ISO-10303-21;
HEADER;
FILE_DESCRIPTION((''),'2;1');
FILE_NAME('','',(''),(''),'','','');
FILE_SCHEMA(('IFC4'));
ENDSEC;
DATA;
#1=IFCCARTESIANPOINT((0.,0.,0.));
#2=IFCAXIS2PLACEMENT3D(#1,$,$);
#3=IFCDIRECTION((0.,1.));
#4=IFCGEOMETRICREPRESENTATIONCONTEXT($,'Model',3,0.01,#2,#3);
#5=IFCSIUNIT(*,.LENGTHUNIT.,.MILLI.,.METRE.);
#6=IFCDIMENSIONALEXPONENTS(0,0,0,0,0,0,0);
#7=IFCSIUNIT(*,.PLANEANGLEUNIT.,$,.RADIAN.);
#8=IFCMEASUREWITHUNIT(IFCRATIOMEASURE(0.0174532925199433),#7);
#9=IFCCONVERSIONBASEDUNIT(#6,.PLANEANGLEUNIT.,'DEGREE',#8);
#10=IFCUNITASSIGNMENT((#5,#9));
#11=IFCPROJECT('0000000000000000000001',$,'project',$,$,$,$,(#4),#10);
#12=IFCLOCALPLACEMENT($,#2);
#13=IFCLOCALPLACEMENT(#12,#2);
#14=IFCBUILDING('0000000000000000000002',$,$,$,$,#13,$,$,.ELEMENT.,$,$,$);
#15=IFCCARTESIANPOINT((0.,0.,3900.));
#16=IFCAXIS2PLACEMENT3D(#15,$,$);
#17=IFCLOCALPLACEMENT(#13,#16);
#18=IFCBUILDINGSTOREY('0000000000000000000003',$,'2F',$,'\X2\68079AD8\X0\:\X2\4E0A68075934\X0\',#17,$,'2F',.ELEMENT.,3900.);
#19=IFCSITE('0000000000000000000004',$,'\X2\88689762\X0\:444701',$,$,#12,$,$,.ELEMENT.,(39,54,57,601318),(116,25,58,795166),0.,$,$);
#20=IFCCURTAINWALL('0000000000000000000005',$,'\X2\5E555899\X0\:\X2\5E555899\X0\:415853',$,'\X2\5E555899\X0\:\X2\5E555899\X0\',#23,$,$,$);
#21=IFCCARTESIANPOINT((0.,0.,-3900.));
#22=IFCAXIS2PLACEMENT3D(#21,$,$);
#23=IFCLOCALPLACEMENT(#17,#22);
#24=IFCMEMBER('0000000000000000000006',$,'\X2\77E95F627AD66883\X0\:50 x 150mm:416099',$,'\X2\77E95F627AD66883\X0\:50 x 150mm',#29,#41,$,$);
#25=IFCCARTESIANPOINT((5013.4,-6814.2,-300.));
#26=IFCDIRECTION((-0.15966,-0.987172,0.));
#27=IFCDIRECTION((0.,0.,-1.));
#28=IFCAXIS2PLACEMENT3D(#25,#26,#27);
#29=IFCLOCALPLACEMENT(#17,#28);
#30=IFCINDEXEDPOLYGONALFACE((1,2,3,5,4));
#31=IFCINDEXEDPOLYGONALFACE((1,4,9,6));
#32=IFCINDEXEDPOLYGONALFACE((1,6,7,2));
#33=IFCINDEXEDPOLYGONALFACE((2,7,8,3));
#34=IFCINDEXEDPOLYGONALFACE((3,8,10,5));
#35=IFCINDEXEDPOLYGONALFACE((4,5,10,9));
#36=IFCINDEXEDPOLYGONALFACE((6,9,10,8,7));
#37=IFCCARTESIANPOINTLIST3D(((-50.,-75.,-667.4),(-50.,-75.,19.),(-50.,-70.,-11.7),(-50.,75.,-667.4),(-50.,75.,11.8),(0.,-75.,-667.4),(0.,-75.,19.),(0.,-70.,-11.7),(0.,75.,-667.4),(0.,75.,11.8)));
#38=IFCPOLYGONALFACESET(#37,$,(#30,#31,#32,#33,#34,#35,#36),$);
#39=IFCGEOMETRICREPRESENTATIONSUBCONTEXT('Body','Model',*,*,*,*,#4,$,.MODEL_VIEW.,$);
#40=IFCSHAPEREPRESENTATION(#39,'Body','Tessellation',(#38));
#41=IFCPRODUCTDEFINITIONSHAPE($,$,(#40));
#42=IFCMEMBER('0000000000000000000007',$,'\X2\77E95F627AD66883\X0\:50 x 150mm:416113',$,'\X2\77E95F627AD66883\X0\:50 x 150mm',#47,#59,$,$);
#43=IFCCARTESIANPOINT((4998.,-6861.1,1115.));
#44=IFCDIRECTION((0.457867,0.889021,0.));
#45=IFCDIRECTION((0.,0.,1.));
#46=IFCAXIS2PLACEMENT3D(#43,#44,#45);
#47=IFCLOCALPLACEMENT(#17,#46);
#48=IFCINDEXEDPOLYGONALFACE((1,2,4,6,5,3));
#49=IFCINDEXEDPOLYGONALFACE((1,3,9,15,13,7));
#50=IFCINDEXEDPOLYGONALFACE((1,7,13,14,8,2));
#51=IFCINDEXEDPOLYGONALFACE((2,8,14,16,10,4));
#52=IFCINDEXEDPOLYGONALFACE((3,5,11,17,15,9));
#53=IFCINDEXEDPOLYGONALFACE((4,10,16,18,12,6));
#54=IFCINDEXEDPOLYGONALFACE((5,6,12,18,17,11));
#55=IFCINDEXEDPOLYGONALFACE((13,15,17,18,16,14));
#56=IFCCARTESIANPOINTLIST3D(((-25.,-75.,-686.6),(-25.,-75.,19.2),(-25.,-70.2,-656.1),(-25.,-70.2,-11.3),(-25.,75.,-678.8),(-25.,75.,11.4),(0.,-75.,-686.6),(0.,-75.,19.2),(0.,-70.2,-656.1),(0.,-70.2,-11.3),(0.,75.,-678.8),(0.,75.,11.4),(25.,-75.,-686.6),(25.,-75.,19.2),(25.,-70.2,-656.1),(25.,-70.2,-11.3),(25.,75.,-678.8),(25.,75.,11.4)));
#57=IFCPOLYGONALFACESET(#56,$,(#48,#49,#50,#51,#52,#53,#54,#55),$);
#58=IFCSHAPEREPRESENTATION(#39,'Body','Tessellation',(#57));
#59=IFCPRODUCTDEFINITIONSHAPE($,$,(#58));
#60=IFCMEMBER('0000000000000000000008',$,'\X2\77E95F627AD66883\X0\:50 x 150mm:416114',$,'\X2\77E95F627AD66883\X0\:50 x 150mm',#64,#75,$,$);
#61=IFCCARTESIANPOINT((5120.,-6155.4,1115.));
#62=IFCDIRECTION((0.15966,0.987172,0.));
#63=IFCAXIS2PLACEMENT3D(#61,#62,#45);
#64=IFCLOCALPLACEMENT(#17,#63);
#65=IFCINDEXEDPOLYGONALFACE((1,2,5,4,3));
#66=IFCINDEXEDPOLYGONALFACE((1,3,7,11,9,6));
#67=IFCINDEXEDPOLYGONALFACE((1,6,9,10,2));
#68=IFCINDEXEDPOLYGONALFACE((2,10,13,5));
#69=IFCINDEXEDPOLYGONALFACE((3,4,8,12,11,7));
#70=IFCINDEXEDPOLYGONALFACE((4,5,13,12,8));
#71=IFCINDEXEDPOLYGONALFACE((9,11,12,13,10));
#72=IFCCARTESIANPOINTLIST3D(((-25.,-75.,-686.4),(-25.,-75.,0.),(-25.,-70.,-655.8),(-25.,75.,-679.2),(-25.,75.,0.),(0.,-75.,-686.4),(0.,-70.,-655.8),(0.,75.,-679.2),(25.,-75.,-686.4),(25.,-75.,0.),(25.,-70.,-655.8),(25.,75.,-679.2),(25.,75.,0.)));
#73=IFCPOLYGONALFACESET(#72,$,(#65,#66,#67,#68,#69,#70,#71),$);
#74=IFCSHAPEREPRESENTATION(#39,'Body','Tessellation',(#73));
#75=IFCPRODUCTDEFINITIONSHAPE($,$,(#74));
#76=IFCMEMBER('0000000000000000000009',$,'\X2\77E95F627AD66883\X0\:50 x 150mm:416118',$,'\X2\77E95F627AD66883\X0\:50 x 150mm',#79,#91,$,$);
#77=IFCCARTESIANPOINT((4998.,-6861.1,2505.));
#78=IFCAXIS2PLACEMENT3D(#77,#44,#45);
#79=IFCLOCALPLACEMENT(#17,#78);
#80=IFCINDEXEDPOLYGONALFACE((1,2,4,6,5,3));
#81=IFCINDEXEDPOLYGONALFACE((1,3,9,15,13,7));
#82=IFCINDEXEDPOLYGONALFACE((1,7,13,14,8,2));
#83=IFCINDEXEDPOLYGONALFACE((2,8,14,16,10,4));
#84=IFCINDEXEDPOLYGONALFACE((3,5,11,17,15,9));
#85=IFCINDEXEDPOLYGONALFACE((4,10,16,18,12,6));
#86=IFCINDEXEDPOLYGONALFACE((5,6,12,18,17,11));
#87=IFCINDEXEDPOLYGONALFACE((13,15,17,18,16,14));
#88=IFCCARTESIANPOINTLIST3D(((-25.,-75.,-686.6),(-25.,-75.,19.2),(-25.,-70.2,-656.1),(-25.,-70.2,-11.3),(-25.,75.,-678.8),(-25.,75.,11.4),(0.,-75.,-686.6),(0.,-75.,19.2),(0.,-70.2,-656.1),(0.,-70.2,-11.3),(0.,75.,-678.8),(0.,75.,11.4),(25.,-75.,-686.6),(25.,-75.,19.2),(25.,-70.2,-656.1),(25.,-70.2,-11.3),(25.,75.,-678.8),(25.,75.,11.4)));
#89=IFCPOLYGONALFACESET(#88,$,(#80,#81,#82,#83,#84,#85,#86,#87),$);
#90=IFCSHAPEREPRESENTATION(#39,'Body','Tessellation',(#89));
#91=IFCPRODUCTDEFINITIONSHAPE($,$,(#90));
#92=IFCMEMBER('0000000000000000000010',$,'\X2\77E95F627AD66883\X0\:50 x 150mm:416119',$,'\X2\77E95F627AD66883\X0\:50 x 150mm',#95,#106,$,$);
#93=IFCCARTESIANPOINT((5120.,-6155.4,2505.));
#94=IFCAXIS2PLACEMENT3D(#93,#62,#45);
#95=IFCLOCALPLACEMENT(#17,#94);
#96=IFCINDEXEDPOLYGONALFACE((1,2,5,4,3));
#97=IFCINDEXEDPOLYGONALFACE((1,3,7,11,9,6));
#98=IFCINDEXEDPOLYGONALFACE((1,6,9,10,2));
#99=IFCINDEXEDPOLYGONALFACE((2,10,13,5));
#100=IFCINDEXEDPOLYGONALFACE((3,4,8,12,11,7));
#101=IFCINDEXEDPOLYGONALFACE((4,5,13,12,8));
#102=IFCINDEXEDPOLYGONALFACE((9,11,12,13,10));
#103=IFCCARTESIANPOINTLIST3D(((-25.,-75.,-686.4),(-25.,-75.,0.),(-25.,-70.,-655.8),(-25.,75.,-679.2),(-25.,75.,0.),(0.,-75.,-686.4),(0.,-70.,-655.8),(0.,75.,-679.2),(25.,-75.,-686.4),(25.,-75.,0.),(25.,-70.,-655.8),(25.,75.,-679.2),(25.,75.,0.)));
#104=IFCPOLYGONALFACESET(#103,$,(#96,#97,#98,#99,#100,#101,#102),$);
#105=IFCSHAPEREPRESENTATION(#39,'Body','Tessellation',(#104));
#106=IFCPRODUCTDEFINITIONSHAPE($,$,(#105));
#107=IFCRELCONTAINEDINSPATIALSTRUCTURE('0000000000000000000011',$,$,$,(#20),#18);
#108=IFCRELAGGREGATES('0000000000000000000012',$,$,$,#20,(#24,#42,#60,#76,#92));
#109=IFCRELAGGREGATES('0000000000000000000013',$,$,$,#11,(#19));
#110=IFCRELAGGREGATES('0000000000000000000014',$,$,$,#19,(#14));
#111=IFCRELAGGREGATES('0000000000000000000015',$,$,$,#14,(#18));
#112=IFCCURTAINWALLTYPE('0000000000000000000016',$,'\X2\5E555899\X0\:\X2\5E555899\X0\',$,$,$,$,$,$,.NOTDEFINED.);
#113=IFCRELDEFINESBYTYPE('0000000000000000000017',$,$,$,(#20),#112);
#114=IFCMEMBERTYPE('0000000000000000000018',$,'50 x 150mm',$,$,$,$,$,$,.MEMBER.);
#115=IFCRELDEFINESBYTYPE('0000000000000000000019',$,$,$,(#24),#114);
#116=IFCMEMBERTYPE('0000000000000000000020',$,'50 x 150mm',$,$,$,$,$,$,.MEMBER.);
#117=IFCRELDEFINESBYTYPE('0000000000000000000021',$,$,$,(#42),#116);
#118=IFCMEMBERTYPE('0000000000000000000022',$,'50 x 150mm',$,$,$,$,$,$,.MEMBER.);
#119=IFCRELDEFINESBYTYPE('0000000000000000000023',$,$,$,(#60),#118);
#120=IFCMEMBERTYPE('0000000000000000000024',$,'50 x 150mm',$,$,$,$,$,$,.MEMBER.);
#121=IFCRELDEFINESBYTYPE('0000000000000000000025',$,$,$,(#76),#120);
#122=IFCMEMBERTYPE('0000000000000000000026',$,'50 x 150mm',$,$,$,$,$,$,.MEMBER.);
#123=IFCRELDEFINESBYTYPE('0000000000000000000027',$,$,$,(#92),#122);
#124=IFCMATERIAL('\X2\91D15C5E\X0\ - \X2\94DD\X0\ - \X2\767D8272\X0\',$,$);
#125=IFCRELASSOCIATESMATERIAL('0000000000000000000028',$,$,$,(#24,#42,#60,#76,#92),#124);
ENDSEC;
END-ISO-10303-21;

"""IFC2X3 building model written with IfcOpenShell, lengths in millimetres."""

from ifc_helpers import new_model, entity, si_unit, converted_unit, direction, frame, frame_2d, origin, origin_2d_with_axis, place, context, subcontext, project, spatial, polyline, rectangle, extrude, clip, bounded_halfspace, source, transform, mapped, material, type_object, type_shapes, element, aggregate, save


model = new_model("IFC2X3")

# Units and contexts
model_context = context("Model", 3, precision=0.01, world=origin(), true_north=direction((0.0, 1.0)))
body_context = subcontext(model_context, "Body", "Model", "MODEL_VIEW")
ifc_project = project(units=[si_unit("LENGTHUNIT", "METRE", prefix="MILLI"), converted_unit("PLANEANGLEUNIT", "DEGREE", entity("IfcRatioMeasure", 0.0174532925199433), si_unit("PLANEANGLEUNIT", "RADIAN"), dimensions=[0, 0, 0, 0, 0, 0, 0])], contexts=[model_context])

# Site, building, storey
site_placement = place(None, origin())
site = spatial("IfcSite", under=ifc_project, at=site_placement, Name="表面:444701", CompositionType="ELEMENT", RefLatitude=(39, 54, 57, 601318), RefLongitude=(116, 25, 58, 795166), RefElevation=0.0)
building_placement = place(site_placement, origin())
building = spatial("IfcBuilding", under=site, at=building_placement, CompositionType="ELEMENT")
storey_placement = place(building_placement, frame((0.0, 0.0, 3900.0)))
storey = spatial("IfcBuildingStorey", under=building, at=storey_placement, Name="2F", ObjectType="标高:上标头", LongName="2F", CompositionType="ELEMENT", Elevation=3900.0)

# Curtain wall
curtain_wall_type = type_object("IfcCurtainWallType", Name="幕墙:幕墙", PredefinedType="NOTDEFINED")
curtain_wall_1_placement = place(storey_placement, frame((0.0, 0.0, -3900.0)))
curtain_wall_1 = element("IfcCurtainWall", 1, at=curtain_wall_1_placement, inside=storey, type_object=curtain_wall_type, Name="幕墙:幕墙:415853", ObjectType="幕墙:幕墙")
ifc_material_1 = material(Name="金属 - 铝 - 白色")

# Members
member_type_1 = type_object("IfcMemberType", Name="50 x 150mm", PredefinedType="MEMBER")
shared_shape_1 = source(origin(), body_context, "Body", "Clipping", [
    clip(clip(extrude(rectangle(XDim=50.0, YDim=150.0, at=frame_2d((0.0, 0.0), x_axis=(1.0, 0.0))), frame((-25.0, 0.0, -667.4)), (0.0, 0.0, 1.0), 686.4), bounded_halfspace(frame((0.0, -78.0, 37.7), z_axis=(0.0, 0.987172, 0.15966), x_axis=(-1.0, 0.0, 0.0)), False, frame((-25.0, 0.0, -667.4)), polyline([(-25.0, -70.0), (-25.0, -75.0), (25.0, -75.0), (25.0, -70.0), (-25.0, -70.0)]))), bounded_halfspace(frame((0.0, -70.0, -11.7), z_axis=(0.0, -0.15966, 0.987172), x_axis=(-1.0, 0.0, 0.0)), False, frame((-25.0, 0.0, -667.4)), polyline([(25.0, 75.0), (-25.0, 75.0), (-25.0, -70.0), (25.0, -70.0), (25.0, 75.0)]))),
])
type_shapes(member_type_1, [shared_shape_1])
member_1_placement = place(storey_placement, frame((5013.4, -6814.2, -300.0), z_axis=(-0.15966, -0.987172, 0.0), x_axis=(0.0, 0.0, -1.0)))
member_1 = element("IfcMember", 2, at=member_1_placement, type_object=member_type_1, material=ifc_material_1, Name="矩形竖梃:50 x 150mm:416099", ObjectType="矩形竖梃:50 x 150mm", context=body_context, shape_type="MappedRepresentation", body=[
    mapped(shared_shape_1, transform((0.0, 0.0, 0.0), scale=1.0)),
])
member_type_2 = type_object("IfcMemberType", Name="50 x 150mm", PredefinedType="MEMBER")
shared_shape_2 = source(origin(), body_context, "Body", "Clipping", [
    clip(clip(clip(clip(clip(clip(clip(clip(extrude(rectangle(XDim=150.0, YDim=50.0, at=origin_2d_with_axis()), frame((0.0, 0.0, -686.6), z_axis=(0.0, 0.0, 1.0), x_axis=(0.0, -1.0, 0.0)), (0.0, 0.0, 1.0), 705.8), bounded_halfspace(frame((-1415.0, -70.2, -656.1), z_axis=(0.0, -0.154283, -0.988027), x_axis=(1.0, 0.0, 0.0)), False, frame((0.0, 0.0, -686.6), z_axis=(0.0, 0.0, 1.0), x_axis=(0.0, -1.0, 0.0)), polyline([(70.2, -25.0), (-75.0, -25.0), (-75.0, 0.0), (70.2, 0.0), (70.2, -25.0)]))), bounded_halfspace(frame((0.0, -70.2, -656.1), z_axis=(0.0, -0.154283, -0.988027), x_axis=(1.0, 0.0, 0.0)), False, frame((0.0, 0.0, -686.6), z_axis=(0.0, 0.0, 1.0), x_axis=(0.0, -1.0, 0.0)), polyline([(-75.0, 25.0), (70.2, 25.0), (70.2, 0.0), (-75.0, 0.0), (-75.0, 25.0)]))), bounded_halfspace(frame((-1415.0, -78.0, -705.5), z_axis=(0.0, 0.988027, -0.154283), x_axis=(1.0, 0.0, 0.0)), False, frame((0.0, 0.0, -686.6), z_axis=(0.0, 0.0, 1.0), x_axis=(0.0, -1.0, 0.0)), polyline([(75.0, 0.0), (75.0, -25.0), (70.2, -25.0), (70.2, 0.0), (75.0, 0.0)]))), bounded_halfspace(frame((0.0, -78.0, -705.5), z_axis=(0.0, 0.988027, -0.154283), x_axis=(1.0, 0.0, 0.0)), False, frame((0.0, 0.0, -686.6), z_axis=(0.0, 0.0, 1.0), x_axis=(0.0, -1.0, 0.0)), polyline([(70.2, 25.0), (75.0, 25.0), (75.0, 0.0), (70.2, 0.0), (70.2, 25.0)]))), bounded_halfspace(frame((-1415.0, -70.2, -11.3), z_axis=(0.0, 0.988027, 0.154283), x_axis=(1.0, 0.0, 0.0)), False, frame((0.0, 0.0, -686.6), z_axis=(0.0, 0.0, 1.0), x_axis=(0.0, -1.0, 0.0)), polyline([(70.2, -25.0), (75.0, -25.0), (75.0, 0.0), (70.2, 0.0), (70.2, -25.0)]))), bounded_halfspace(frame((0.0, -70.2, -11.3), z_axis=(0.0, 0.988027, 0.154283), x_axis=(1.0, 0.0, 0.0)), False, frame((0.0, 0.0, -686.6), z_axis=(0.0, 0.0, 1.0), x_axis=(0.0, -1.0, 0.0)), polyline([(75.0, 0.0), (75.0, 25.0), (70.2, 25.0), (70.2, 0.0), (75.0, 0.0)]))), bounded_halfspace(frame((-1415.0, 78.0, 11.9), z_axis=(0.0, -0.154283, 0.988027), x_axis=(1.0, 0.0, 0.0)), False, frame((0.0, 0.0, -686.6), z_axis=(0.0, 0.0, 1.0), x_axis=(0.0, -1.0, 0.0)), polyline([(-75.0, 0.0), (-75.0, -25.0), (70.2, -25.0), (70.2, 0.0), (-75.0, 0.0)]))), bounded_halfspace(frame((0.0, 78.0, 11.9), z_axis=(0.0, -0.154283, 0.988027), x_axis=(1.0, 0.0, 0.0)), False, frame((0.0, 0.0, -686.6), z_axis=(0.0, 0.0, 1.0), x_axis=(0.0, -1.0, 0.0)), polyline([(-75.0, 25.0), (-75.0, 0.0), (70.2, 0.0), (70.2, 25.0), (-75.0, 25.0)]))),
])
type_shapes(member_type_2, [shared_shape_2])
member_2_placement = place(storey_placement, frame((4998.0, -6861.1, 1115.0), z_axis=(0.457867, 0.889021, 0.0), x_axis=(0.0, 0.0, 1.0)))
member_2 = element("IfcMember", 3, at=member_2_placement, type_object=member_type_2, material=ifc_material_1, Name="矩形竖梃:50 x 150mm:416113", ObjectType="矩形竖梃:50 x 150mm", context=body_context, shape_type="MappedRepresentation", body=[
    mapped(shared_shape_2, transform((0.0, 0.0, 0.0), scale=1.0)),
])
member_type_3 = type_object("IfcMemberType", Name="50 x 150mm", PredefinedType="MEMBER")
shared_shape_3 = source(origin(), body_context, "Body", "Clipping", [
    clip(clip(clip(clip(extrude(rectangle(XDim=150.0, YDim=50.0, at=origin_2d_with_axis()), frame((0.0, 0.0, -686.4), z_axis=(0.0, 0.0, 1.0), x_axis=(0.0, -1.0, 0.0)), (0.0, 0.0, 1.0), 686.4), bounded_halfspace(frame((-1415.0, -70.0, -655.8), z_axis=(0.0, -0.15966, -0.987172), x_axis=(1.0, 0.0, 0.0)), False, frame((0.0, 0.0, -686.4), z_axis=(0.0, 0.0, 1.0), x_axis=(0.0, -1.0, 0.0)), polyline([(70.0, -25.0), (-75.0, -25.0), (-75.0, 0.0), (70.0, 0.0), (70.0, -25.0)]))), bounded_halfspace(frame((0.0, -70.0, -655.8), z_axis=(0.0, -0.15966, -0.987172), x_axis=(1.0, 0.0, 0.0)), False, frame((0.0, 0.0, -686.4), z_axis=(0.0, 0.0, 1.0), x_axis=(0.0, -1.0, 0.0)), polyline([(-75.0, 25.0), (70.0, 25.0), (70.0, 0.0), (-75.0, 0.0), (-75.0, 25.0)]))), bounded_halfspace(frame((-1415.0, -78.0, -705.1), z_axis=(0.0, 0.987172, -0.15966), x_axis=(1.0, 0.0, 0.0)), False, frame((0.0, 0.0, -686.4), z_axis=(0.0, 0.0, 1.0), x_axis=(0.0, -1.0, 0.0)), polyline([(75.0, 0.0), (75.0, -25.0), (70.0, -25.0), (70.0, 0.0), (75.0, 0.0)]))), bounded_halfspace(frame((0.0, -78.0, -705.1), z_axis=(0.0, 0.987172, -0.15966), x_axis=(1.0, 0.0, 0.0)), False, frame((0.0, 0.0, -686.4), z_axis=(0.0, 0.0, 1.0), x_axis=(0.0, -1.0, 0.0)), polyline([(70.0, 25.0), (75.0, 25.0), (75.0, 0.0), (70.0, 0.0), (70.0, 25.0)]))),
])
type_shapes(member_type_3, [shared_shape_3])
member_3_placement = place(storey_placement, frame((5120.0, -6155.4, 1115.0), z_axis=(0.15966, 0.987172, 0.0), x_axis=(0.0, 0.0, 1.0)))
member_3 = element("IfcMember", 4, at=member_3_placement, type_object=member_type_3, material=ifc_material_1, Name="矩形竖梃:50 x 150mm:416114", ObjectType="矩形竖梃:50 x 150mm", context=body_context, shape_type="MappedRepresentation", body=[
    mapped(shared_shape_3, transform((0.0, 0.0, 0.0), scale=1.0)),
])
member_type_4 = type_object("IfcMemberType", Name="50 x 150mm", PredefinedType="MEMBER")
shared_shape_4 = source(origin(), body_context, "Body", "Clipping", [
    clip(clip(clip(clip(clip(clip(clip(clip(extrude(rectangle(XDim=150.0, YDim=50.0, at=origin_2d_with_axis()), frame((0.0, 0.0, -686.6), z_axis=(0.0, 0.0, 1.0), x_axis=(0.0, -1.0, 0.0)), (0.0, 0.0, 1.0), 705.8), bounded_halfspace(frame((-1390.0, -70.2, -656.1), z_axis=(0.0, -0.154283, -0.988027), x_axis=(1.0, 0.0, 0.0)), False, frame((0.0, 0.0, -686.6), z_axis=(0.0, 0.0, 1.0), x_axis=(0.0, -1.0, 0.0)), polyline([(70.2, -25.0), (-75.0, -25.0), (-75.0, 0.0), (70.2, 0.0), (70.2, -25.0)]))), bounded_halfspace(frame((0.0, -70.2, -656.1), z_axis=(0.0, -0.154283, -0.988027), x_axis=(1.0, 0.0, 0.0)), False, frame((0.0, 0.0, -686.6), z_axis=(0.0, 0.0, 1.0), x_axis=(0.0, -1.0, 0.0)), polyline([(-75.0, 25.0), (70.2, 25.0), (70.2, 0.0), (-75.0, 0.0), (-75.0, 25.0)]))), bounded_halfspace(frame((-1390.0, -78.0, -705.5), z_axis=(0.0, 0.988027, -0.154283), x_axis=(1.0, 0.0, 0.0)), False, frame((0.0, 0.0, -686.6), z_axis=(0.0, 0.0, 1.0), x_axis=(0.0, -1.0, 0.0)), polyline([(75.0, 0.0), (75.0, -25.0), (70.2, -25.0), (70.2, 0.0), (75.0, 0.0)]))), bounded_halfspace(frame((0.0, -78.0, -705.5), z_axis=(0.0, 0.988027, -0.154283), x_axis=(1.0, 0.0, 0.0)), False, frame((0.0, 0.0, -686.6), z_axis=(0.0, 0.0, 1.0), x_axis=(0.0, -1.0, 0.0)), polyline([(70.2, 25.0), (75.0, 25.0), (75.0, 0.0), (70.2, 0.0), (70.2, 25.0)]))), bounded_halfspace(frame((-1390.0, -70.2, -11.3), z_axis=(0.0, 0.988027, 0.154283), x_axis=(1.0, 0.0, 0.0)), False, frame((0.0, 0.0, -686.6), z_axis=(0.0, 0.0, 1.0), x_axis=(0.0, -1.0, 0.0)), polyline([(70.2, -25.0), (75.0, -25.0), (75.0, 0.0), (70.2, 0.0), (70.2, -25.0)]))), bounded_halfspace(frame((0.0, -70.2, -11.3), z_axis=(0.0, 0.988027, 0.154283), x_axis=(1.0, 0.0, 0.0)), False, frame((0.0, 0.0, -686.6), z_axis=(0.0, 0.0, 1.0), x_axis=(0.0, -1.0, 0.0)), polyline([(75.0, 0.0), (75.0, 25.0), (70.2, 25.0), (70.2, 0.0), (75.0, 0.0)]))), bounded_halfspace(frame((-1390.0, 78.0, 11.9), z_axis=(0.0, -0.154283, 0.988027), x_axis=(1.0, 0.0, 0.0)), False, frame((0.0, 0.0, -686.6), z_axis=(0.0, 0.0, 1.0), x_axis=(0.0, -1.0, 0.0)), polyline([(-75.0, 0.0), (-75.0, -25.0), (70.2, -25.0), (70.2, 0.0), (-75.0, 0.0)]))), bounded_halfspace(frame((0.0, 78.0, 11.9), z_axis=(0.0, -0.154283, 0.988027), x_axis=(1.0, 0.0, 0.0)), False, frame((0.0, 0.0, -686.6), z_axis=(0.0, 0.0, 1.0), x_axis=(0.0, -1.0, 0.0)), polyline([(-75.0, 25.0), (-75.0, 0.0), (70.2, 0.0), (70.2, 25.0), (-75.0, 25.0)]))),
])
type_shapes(member_type_4, [shared_shape_4])
member_4_placement = place(storey_placement, frame((4998.0, -6861.1, 2505.0), z_axis=(0.457867, 0.889021, 0.0), x_axis=(0.0, 0.0, 1.0)))
member_4 = element("IfcMember", 5, at=member_4_placement, type_object=member_type_4, material=ifc_material_1, Name="矩形竖梃:50 x 150mm:416118", ObjectType="矩形竖梃:50 x 150mm", context=body_context, shape_type="MappedRepresentation", body=[
    mapped(shared_shape_4, transform((0.0, 0.0, 0.0), scale=1.0)),
])
member_type_5 = type_object("IfcMemberType", Name="50 x 150mm", PredefinedType="MEMBER")
shared_shape_5 = source(origin(), body_context, "Body", "Clipping", [
    clip(clip(clip(clip(extrude(rectangle(XDim=150.0, YDim=50.0, at=origin_2d_with_axis()), frame((0.0, 0.0, -686.4), z_axis=(0.0, 0.0, 1.0), x_axis=(0.0, -1.0, 0.0)), (0.0, 0.0, 1.0), 686.4), bounded_halfspace(frame((-1390.0, -70.0, -655.8), z_axis=(0.0, -0.15966, -0.987172), x_axis=(1.0, 0.0, 0.0)), False, frame((0.0, 0.0, -686.4), z_axis=(0.0, 0.0, 1.0), x_axis=(0.0, -1.0, 0.0)), polyline([(70.0, -25.0), (-75.0, -25.0), (-75.0, 0.0), (70.0, 0.0), (70.0, -25.0)]))), bounded_halfspace(frame((0.0, -70.0, -655.8), z_axis=(0.0, -0.15966, -0.987172), x_axis=(1.0, 0.0, 0.0)), False, frame((0.0, 0.0, -686.4), z_axis=(0.0, 0.0, 1.0), x_axis=(0.0, -1.0, 0.0)), polyline([(-75.0, 25.0), (70.0, 25.0), (70.0, 0.0), (-75.0, 0.0), (-75.0, 25.0)]))), bounded_halfspace(frame((-1390.0, -78.0, -705.1), z_axis=(0.0, 0.987172, -0.15966), x_axis=(1.0, 0.0, 0.0)), False, frame((0.0, 0.0, -686.4), z_axis=(0.0, 0.0, 1.0), x_axis=(0.0, -1.0, 0.0)), polyline([(75.0, 0.0), (75.0, -25.0), (70.0, -25.0), (70.0, 0.0), (75.0, 0.0)]))), bounded_halfspace(frame((0.0, -78.0, -705.1), z_axis=(0.0, 0.987172, -0.15966), x_axis=(1.0, 0.0, 0.0)), False, frame((0.0, 0.0, -686.4), z_axis=(0.0, 0.0, 1.0), x_axis=(0.0, -1.0, 0.0)), polyline([(70.0, 25.0), (75.0, 25.0), (75.0, 0.0), (70.0, 0.0), (70.0, 25.0)]))),
])
type_shapes(member_type_5, [shared_shape_5])
member_5_placement = place(storey_placement, frame((5120.0, -6155.4, 2505.0), z_axis=(0.15966, 0.987172, 0.0), x_axis=(0.0, 0.0, 1.0)))
member_5 = element("IfcMember", 6, at=member_5_placement, type_object=member_type_5, material=ifc_material_1, Name="矩形竖梃:50 x 150mm:416119", ObjectType="矩形竖梃:50 x 150mm", context=body_context, shape_type="MappedRepresentation", body=[
    mapped(shared_shape_5, transform((0.0, 0.0, 0.0), scale=1.0)),
])

aggregate(curtain_wall_1, [member_1, member_2, member_3, member_4, member_5])

save(model, "model.ifc")
